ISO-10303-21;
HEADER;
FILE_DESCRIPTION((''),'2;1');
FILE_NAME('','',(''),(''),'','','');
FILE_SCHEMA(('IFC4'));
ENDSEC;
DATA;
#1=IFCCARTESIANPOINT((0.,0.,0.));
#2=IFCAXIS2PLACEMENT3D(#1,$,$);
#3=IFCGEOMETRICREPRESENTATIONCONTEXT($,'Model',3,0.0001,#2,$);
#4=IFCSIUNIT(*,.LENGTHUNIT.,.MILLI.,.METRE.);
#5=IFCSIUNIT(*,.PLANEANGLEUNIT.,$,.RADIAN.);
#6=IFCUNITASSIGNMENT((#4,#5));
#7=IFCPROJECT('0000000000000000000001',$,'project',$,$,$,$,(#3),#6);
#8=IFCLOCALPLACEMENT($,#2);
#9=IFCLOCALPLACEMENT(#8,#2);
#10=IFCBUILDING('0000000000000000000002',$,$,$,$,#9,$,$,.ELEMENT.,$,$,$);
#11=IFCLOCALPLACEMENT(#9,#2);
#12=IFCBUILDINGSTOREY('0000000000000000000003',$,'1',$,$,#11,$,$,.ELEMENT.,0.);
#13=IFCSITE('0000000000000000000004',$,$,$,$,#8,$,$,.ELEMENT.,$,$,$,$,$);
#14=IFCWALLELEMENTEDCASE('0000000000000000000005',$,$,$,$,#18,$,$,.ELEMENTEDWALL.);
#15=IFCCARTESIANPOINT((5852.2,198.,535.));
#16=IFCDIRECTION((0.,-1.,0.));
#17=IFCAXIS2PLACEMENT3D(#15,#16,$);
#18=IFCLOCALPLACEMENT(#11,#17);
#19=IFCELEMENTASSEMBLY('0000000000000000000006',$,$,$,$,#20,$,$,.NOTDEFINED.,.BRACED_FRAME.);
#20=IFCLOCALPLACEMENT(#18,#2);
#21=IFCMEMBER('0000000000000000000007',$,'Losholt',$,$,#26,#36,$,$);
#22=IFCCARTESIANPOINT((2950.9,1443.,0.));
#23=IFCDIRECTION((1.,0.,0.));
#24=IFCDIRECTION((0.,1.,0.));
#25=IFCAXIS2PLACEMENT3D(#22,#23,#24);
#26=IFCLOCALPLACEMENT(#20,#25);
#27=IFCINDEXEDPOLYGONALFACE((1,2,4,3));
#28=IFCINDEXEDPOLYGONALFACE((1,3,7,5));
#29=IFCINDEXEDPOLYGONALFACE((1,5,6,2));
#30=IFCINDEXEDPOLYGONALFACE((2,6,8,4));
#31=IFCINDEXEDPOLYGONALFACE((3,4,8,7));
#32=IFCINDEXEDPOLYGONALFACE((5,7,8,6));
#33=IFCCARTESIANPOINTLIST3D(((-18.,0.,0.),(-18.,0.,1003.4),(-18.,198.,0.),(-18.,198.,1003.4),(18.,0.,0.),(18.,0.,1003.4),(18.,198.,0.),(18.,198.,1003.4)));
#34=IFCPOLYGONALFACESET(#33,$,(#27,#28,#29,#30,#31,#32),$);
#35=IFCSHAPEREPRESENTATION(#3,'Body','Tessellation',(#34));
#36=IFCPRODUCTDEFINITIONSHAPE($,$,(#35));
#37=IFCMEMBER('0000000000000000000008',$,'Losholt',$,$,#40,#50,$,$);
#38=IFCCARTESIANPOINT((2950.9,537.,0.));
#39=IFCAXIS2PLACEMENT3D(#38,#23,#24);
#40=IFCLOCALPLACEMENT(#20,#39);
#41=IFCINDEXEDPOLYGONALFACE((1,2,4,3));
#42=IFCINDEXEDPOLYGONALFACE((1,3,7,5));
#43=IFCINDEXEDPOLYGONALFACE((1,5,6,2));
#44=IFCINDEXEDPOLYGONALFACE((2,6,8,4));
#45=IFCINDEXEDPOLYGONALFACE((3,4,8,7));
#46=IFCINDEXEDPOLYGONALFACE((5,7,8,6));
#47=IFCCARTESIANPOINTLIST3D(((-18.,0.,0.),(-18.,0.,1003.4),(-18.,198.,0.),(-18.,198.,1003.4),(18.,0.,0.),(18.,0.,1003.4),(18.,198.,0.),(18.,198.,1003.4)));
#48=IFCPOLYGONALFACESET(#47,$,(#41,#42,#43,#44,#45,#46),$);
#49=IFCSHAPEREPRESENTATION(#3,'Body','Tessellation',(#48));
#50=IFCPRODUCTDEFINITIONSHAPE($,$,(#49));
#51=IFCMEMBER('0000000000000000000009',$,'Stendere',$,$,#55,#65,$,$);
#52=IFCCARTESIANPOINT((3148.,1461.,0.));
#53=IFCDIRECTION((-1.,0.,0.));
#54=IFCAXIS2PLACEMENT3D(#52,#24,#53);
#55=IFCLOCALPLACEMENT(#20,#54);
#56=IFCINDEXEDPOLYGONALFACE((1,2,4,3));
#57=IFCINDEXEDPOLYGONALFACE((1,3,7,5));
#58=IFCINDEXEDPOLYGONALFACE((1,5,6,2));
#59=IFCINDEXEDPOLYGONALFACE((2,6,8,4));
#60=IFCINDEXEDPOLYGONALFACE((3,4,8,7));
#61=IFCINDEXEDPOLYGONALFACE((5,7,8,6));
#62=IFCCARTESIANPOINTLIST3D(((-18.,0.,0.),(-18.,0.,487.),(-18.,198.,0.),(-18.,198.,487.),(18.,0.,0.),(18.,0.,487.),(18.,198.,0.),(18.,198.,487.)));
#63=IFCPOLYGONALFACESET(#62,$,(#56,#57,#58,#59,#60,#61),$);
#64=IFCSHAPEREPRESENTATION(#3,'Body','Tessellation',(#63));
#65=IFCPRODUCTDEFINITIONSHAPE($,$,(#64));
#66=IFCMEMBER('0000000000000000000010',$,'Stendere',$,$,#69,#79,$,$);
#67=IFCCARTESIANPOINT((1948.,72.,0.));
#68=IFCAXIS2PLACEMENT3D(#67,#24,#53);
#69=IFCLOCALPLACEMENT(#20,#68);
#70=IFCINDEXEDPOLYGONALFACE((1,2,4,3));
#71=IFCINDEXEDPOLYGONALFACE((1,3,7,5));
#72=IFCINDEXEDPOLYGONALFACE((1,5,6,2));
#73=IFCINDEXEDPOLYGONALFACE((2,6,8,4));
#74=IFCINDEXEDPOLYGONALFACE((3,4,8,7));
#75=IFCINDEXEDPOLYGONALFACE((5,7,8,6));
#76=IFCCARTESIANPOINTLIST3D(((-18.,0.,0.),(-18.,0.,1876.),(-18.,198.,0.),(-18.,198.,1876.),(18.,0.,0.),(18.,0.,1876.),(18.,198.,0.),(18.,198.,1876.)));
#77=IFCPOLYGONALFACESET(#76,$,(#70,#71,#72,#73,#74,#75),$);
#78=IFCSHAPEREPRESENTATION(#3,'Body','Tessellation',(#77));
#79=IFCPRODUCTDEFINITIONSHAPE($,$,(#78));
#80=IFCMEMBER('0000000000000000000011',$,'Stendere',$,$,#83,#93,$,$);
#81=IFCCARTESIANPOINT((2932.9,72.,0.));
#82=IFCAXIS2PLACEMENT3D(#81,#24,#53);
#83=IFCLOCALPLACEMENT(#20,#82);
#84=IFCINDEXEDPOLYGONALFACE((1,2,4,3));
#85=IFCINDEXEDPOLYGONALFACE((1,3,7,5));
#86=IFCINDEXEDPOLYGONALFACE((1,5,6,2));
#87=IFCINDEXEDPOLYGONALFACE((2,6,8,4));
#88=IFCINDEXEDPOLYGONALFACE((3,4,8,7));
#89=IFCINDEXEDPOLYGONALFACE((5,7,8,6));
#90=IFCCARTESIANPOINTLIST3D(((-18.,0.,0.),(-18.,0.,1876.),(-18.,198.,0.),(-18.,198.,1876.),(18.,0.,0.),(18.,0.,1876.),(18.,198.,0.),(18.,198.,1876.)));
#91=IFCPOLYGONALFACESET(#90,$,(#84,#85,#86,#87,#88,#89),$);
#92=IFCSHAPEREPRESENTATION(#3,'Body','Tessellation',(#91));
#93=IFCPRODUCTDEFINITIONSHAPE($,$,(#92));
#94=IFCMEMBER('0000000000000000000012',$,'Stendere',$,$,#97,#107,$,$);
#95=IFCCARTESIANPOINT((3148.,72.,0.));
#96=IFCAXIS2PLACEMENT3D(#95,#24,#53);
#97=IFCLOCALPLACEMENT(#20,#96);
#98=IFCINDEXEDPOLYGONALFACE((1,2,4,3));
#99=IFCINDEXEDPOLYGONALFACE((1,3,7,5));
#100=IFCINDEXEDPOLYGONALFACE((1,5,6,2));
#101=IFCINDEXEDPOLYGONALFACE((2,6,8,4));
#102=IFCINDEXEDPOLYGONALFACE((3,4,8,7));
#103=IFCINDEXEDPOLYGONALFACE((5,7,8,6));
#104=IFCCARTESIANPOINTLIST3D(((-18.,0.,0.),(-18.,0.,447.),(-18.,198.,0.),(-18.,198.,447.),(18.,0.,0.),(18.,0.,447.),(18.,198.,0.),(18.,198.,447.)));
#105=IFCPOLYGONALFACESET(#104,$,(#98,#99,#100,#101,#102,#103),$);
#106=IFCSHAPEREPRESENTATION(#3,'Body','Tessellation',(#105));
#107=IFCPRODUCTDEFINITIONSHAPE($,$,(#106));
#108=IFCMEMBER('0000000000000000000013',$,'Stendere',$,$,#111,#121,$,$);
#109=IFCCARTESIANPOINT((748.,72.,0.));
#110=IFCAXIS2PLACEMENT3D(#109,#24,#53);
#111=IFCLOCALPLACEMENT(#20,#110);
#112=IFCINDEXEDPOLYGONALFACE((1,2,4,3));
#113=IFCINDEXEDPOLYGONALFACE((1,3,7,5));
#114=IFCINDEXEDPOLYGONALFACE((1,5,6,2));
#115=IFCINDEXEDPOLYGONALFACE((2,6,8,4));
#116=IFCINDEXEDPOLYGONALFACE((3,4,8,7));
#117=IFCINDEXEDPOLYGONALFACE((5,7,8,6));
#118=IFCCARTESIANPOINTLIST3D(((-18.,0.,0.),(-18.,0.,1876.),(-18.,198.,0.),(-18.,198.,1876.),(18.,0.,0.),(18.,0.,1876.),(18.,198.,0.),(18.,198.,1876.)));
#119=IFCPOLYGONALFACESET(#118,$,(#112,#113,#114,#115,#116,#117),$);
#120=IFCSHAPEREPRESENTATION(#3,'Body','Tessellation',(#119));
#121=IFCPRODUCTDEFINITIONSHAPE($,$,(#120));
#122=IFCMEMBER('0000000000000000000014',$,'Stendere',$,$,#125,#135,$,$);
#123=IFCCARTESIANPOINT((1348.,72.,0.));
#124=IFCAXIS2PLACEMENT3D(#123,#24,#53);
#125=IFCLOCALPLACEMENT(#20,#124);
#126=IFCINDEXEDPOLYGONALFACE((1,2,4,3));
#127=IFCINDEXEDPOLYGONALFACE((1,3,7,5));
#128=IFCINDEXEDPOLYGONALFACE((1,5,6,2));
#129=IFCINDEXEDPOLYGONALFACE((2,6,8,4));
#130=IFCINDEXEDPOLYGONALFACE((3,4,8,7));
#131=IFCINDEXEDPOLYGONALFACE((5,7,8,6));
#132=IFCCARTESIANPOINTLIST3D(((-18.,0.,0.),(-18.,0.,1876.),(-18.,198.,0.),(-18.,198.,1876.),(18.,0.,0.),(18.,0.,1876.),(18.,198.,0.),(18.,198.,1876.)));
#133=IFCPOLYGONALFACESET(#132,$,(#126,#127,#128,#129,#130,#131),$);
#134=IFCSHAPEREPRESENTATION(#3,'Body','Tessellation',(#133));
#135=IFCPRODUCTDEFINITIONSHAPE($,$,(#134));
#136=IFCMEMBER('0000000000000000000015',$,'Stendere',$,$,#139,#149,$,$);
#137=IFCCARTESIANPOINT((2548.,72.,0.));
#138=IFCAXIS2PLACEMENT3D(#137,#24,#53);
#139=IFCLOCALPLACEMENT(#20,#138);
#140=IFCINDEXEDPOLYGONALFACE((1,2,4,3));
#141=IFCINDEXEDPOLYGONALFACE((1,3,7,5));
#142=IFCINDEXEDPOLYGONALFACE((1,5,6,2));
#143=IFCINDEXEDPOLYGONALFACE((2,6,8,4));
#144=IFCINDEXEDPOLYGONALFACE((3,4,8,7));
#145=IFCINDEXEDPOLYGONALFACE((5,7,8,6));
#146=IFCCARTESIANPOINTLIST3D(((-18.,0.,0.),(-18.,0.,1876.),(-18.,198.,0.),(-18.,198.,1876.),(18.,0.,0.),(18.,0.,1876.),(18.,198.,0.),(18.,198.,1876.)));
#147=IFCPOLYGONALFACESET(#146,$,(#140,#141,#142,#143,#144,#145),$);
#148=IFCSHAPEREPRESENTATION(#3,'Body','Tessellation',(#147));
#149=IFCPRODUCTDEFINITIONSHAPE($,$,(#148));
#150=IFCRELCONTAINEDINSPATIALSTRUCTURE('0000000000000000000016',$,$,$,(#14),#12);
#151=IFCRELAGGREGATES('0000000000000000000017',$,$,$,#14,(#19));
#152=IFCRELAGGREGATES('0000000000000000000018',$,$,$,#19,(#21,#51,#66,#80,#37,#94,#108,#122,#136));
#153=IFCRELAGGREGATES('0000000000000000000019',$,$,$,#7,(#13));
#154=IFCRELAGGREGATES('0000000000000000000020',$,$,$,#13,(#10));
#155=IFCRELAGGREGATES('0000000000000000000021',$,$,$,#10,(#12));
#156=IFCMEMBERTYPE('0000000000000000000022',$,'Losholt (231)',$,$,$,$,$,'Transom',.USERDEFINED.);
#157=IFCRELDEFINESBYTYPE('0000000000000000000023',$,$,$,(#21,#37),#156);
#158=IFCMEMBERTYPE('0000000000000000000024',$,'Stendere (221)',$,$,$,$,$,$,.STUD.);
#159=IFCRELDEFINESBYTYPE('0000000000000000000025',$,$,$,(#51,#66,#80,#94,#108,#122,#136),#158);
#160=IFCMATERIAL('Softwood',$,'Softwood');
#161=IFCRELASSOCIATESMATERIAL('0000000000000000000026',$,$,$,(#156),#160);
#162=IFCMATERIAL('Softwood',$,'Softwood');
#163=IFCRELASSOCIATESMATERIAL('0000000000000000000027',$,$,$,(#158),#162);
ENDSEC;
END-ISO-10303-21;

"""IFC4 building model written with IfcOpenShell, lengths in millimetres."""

from ifc_helpers import new_model, si_unit, frame, origin, place, context, project, spatial, rectangle, extrude, material, material_profile, profile_set, type_object, element, aggregate, save


model = new_model("IFC4")

# Units and contexts
model_context = context("Model", 3, precision=0.0001, world=origin())
ifc_project = project(units=[si_unit("LENGTHUNIT", "METRE", prefix="MILLI"), si_unit("PLANEANGLEUNIT", "RADIAN")], contexts=[model_context])

# Site, building, storey
site_placement = place(None, origin())
site = spatial("IfcSite", under=ifc_project, at=site_placement, CompositionType="ELEMENT")
building_placement = place(site_placement, origin())
building = spatial("IfcBuilding", under=site, at=building_placement, CompositionType="ELEMENT")
storey_placement = place(building_placement, origin())
storey = spatial("IfcBuildingStorey", under=building, at=storey_placement, Name="1", CompositionType="ELEMENT", Elevation=0.0)

# Wall, element assembly, members
wall_1_placement = place(storey_placement, frame((5852.2, 198.0, 535.0), z_axis=(0.0, -1.0, 0.0)))
wall_1 = element("IfcWallElementedCase", 1, at=wall_1_placement, inside=storey, PredefinedType="ELEMENTEDWALL")
assembly_1_placement = place(wall_1_placement, origin())
assembly_1 = element("IfcElementAssembly", 2, at=assembly_1_placement, AssemblyPlace="NOTDEFINED", PredefinedType="BRACED_FRAME")
aggregate(wall_1, [assembly_1])
ifc_material_1 = material(Name="Softwood", Category="Softwood")
ifc_material_profile_1 = material_profile(ifc_material_1, rectangle(XDim=36.0, YDim=198.0), Name="Losholt (231)")
ifc_profile_set_1 = profile_set([ifc_material_profile_1])
member_type_1 = type_object("IfcMemberType", Name="Losholt (231)", ElementType="Transom", PredefinedType="USERDEFINED", material=ifc_profile_set_1)
member_1_placement = place(assembly_1_placement, frame((2950.9, 1443.0, 0.0), z_axis=(1.0, 0.0, 0.0), x_axis=(0.0, 1.0, 0.0)))
member_1 = element("IfcMember", 3, at=member_1_placement, type_object=member_type_1, Name="Losholt", context=model_context, shape_type="SweptSolid", body=[
    extrude(rectangle(XDim=36.0, YDim=198.0), frame((0.0, 99.0, 0.0)), (0.0, 0.0, 1.0), 1003.4),
])
member_2_placement = place(assembly_1_placement, frame((2950.9, 537.0, 0.0), z_axis=(1.0, 0.0, 0.0), x_axis=(0.0, 1.0, 0.0)))
member_2 = element("IfcMember", 4, at=member_2_placement, type_object=member_type_1, Name="Losholt", context=model_context, shape_type="SweptSolid", body=[
    extrude(rectangle(XDim=36.0, YDim=198.0), frame((0.0, 99.0, 0.0)), (0.0, 0.0, 1.0), 1003.4),
])

# Members
ifc_material_2 = material(Name="Softwood", Category="Softwood")
ifc_material_profile_2 = material_profile(ifc_material_2, rectangle(XDim=36.0, YDim=198.0), Name="Stendere (221)")
ifc_profile_set_2 = profile_set([ifc_material_profile_2])
member_type_2 = type_object("IfcMemberType", Name="Stendere (221)", PredefinedType="STUD", material=ifc_profile_set_2)
member_3_placement = place(assembly_1_placement, frame((3148.0, 1461.0, 0.0), z_axis=(0.0, 1.0, 0.0), x_axis=(-1.0, 0.0, 0.0)))
member_3 = element("IfcMember", 5, at=member_3_placement, type_object=member_type_2, Name="Stendere", context=model_context, shape_type="SweptSolid", body=[
    extrude(rectangle(XDim=36.0, YDim=198.0), frame((0.0, 99.0, 0.0)), (0.0, 0.0, 1.0), 487.0),
])
member_4_placement = place(assembly_1_placement, frame((1948.0, 72.0, 0.0), z_axis=(0.0, 1.0, 0.0), x_axis=(-1.0, 0.0, 0.0)))
member_4 = element("IfcMember", 6, at=member_4_placement, type_object=member_type_2, Name="Stendere", context=model_context, shape_type="SweptSolid", body=[
    extrude(rectangle(XDim=36.0, YDim=198.0), frame((0.0, 99.0, 0.0)), (0.0, 0.0, 1.0), 1876.0),
])
member_5_placement = place(assembly_1_placement, frame((2932.9, 72.0, 0.0), z_axis=(0.0, 1.0, 0.0), x_axis=(-1.0, 0.0, 0.0)))
member_5 = element("IfcMember", 7, at=member_5_placement, type_object=member_type_2, Name="Stendere", context=model_context, shape_type="SweptSolid", body=[
    extrude(rectangle(XDim=36.0, YDim=198.0), frame((0.0, 99.0, 0.0)), (0.0, 0.0, 1.0), 1876.0),
])
member_6_placement = place(assembly_1_placement, frame((3148.0, 72.0, 0.0), z_axis=(0.0, 1.0, 0.0), x_axis=(-1.0, 0.0, 0.0)))
member_6 = element("IfcMember", 8, at=member_6_placement, type_object=member_type_2, Name="Stendere", context=model_context, shape_type="SweptSolid", body=[
    extrude(rectangle(XDim=36.0, YDim=198.0), frame((0.0, 99.0, 0.0)), (0.0, 0.0, 1.0), 447.0),
])
member_7_placement = place(assembly_1_placement, frame((748.0, 72.0, 0.0), z_axis=(0.0, 1.0, 0.0), x_axis=(-1.0, 0.0, 0.0)))
member_7 = element("IfcMember", 9, at=member_7_placement, type_object=member_type_2, Name="Stendere", context=model_context, shape_type="SweptSolid", body=[
    extrude(rectangle(XDim=36.0, YDim=198.0), frame((0.0, 99.0, 0.0)), (0.0, 0.0, 1.0), 1876.0),
])
member_8_placement = place(assembly_1_placement, frame((1348.0, 72.0, 0.0), z_axis=(0.0, 1.0, 0.0), x_axis=(-1.0, 0.0, 0.0)))
member_8 = element("IfcMember", 10, at=member_8_placement, type_object=member_type_2, Name="Stendere", context=model_context, shape_type="SweptSolid", body=[
    extrude(rectangle(XDim=36.0, YDim=198.0), frame((0.0, 99.0, 0.0)), (0.0, 0.0, 1.0), 1876.0),
])
member_9_placement = place(assembly_1_placement, frame((2548.0, 72.0, 0.0), z_axis=(0.0, 1.0, 0.0), x_axis=(-1.0, 0.0, 0.0)))
member_9 = element("IfcMember", 11, at=member_9_placement, type_object=member_type_2, Name="Stendere", context=model_context, shape_type="SweptSolid", body=[
    extrude(rectangle(XDim=36.0, YDim=198.0), frame((0.0, 99.0, 0.0)), (0.0, 0.0, 1.0), 1876.0),
])
aggregate(assembly_1, [member_1, member_3, member_4, member_5, member_2, member_6, member_7, member_8, member_9])

save(model, "model.ifc")
